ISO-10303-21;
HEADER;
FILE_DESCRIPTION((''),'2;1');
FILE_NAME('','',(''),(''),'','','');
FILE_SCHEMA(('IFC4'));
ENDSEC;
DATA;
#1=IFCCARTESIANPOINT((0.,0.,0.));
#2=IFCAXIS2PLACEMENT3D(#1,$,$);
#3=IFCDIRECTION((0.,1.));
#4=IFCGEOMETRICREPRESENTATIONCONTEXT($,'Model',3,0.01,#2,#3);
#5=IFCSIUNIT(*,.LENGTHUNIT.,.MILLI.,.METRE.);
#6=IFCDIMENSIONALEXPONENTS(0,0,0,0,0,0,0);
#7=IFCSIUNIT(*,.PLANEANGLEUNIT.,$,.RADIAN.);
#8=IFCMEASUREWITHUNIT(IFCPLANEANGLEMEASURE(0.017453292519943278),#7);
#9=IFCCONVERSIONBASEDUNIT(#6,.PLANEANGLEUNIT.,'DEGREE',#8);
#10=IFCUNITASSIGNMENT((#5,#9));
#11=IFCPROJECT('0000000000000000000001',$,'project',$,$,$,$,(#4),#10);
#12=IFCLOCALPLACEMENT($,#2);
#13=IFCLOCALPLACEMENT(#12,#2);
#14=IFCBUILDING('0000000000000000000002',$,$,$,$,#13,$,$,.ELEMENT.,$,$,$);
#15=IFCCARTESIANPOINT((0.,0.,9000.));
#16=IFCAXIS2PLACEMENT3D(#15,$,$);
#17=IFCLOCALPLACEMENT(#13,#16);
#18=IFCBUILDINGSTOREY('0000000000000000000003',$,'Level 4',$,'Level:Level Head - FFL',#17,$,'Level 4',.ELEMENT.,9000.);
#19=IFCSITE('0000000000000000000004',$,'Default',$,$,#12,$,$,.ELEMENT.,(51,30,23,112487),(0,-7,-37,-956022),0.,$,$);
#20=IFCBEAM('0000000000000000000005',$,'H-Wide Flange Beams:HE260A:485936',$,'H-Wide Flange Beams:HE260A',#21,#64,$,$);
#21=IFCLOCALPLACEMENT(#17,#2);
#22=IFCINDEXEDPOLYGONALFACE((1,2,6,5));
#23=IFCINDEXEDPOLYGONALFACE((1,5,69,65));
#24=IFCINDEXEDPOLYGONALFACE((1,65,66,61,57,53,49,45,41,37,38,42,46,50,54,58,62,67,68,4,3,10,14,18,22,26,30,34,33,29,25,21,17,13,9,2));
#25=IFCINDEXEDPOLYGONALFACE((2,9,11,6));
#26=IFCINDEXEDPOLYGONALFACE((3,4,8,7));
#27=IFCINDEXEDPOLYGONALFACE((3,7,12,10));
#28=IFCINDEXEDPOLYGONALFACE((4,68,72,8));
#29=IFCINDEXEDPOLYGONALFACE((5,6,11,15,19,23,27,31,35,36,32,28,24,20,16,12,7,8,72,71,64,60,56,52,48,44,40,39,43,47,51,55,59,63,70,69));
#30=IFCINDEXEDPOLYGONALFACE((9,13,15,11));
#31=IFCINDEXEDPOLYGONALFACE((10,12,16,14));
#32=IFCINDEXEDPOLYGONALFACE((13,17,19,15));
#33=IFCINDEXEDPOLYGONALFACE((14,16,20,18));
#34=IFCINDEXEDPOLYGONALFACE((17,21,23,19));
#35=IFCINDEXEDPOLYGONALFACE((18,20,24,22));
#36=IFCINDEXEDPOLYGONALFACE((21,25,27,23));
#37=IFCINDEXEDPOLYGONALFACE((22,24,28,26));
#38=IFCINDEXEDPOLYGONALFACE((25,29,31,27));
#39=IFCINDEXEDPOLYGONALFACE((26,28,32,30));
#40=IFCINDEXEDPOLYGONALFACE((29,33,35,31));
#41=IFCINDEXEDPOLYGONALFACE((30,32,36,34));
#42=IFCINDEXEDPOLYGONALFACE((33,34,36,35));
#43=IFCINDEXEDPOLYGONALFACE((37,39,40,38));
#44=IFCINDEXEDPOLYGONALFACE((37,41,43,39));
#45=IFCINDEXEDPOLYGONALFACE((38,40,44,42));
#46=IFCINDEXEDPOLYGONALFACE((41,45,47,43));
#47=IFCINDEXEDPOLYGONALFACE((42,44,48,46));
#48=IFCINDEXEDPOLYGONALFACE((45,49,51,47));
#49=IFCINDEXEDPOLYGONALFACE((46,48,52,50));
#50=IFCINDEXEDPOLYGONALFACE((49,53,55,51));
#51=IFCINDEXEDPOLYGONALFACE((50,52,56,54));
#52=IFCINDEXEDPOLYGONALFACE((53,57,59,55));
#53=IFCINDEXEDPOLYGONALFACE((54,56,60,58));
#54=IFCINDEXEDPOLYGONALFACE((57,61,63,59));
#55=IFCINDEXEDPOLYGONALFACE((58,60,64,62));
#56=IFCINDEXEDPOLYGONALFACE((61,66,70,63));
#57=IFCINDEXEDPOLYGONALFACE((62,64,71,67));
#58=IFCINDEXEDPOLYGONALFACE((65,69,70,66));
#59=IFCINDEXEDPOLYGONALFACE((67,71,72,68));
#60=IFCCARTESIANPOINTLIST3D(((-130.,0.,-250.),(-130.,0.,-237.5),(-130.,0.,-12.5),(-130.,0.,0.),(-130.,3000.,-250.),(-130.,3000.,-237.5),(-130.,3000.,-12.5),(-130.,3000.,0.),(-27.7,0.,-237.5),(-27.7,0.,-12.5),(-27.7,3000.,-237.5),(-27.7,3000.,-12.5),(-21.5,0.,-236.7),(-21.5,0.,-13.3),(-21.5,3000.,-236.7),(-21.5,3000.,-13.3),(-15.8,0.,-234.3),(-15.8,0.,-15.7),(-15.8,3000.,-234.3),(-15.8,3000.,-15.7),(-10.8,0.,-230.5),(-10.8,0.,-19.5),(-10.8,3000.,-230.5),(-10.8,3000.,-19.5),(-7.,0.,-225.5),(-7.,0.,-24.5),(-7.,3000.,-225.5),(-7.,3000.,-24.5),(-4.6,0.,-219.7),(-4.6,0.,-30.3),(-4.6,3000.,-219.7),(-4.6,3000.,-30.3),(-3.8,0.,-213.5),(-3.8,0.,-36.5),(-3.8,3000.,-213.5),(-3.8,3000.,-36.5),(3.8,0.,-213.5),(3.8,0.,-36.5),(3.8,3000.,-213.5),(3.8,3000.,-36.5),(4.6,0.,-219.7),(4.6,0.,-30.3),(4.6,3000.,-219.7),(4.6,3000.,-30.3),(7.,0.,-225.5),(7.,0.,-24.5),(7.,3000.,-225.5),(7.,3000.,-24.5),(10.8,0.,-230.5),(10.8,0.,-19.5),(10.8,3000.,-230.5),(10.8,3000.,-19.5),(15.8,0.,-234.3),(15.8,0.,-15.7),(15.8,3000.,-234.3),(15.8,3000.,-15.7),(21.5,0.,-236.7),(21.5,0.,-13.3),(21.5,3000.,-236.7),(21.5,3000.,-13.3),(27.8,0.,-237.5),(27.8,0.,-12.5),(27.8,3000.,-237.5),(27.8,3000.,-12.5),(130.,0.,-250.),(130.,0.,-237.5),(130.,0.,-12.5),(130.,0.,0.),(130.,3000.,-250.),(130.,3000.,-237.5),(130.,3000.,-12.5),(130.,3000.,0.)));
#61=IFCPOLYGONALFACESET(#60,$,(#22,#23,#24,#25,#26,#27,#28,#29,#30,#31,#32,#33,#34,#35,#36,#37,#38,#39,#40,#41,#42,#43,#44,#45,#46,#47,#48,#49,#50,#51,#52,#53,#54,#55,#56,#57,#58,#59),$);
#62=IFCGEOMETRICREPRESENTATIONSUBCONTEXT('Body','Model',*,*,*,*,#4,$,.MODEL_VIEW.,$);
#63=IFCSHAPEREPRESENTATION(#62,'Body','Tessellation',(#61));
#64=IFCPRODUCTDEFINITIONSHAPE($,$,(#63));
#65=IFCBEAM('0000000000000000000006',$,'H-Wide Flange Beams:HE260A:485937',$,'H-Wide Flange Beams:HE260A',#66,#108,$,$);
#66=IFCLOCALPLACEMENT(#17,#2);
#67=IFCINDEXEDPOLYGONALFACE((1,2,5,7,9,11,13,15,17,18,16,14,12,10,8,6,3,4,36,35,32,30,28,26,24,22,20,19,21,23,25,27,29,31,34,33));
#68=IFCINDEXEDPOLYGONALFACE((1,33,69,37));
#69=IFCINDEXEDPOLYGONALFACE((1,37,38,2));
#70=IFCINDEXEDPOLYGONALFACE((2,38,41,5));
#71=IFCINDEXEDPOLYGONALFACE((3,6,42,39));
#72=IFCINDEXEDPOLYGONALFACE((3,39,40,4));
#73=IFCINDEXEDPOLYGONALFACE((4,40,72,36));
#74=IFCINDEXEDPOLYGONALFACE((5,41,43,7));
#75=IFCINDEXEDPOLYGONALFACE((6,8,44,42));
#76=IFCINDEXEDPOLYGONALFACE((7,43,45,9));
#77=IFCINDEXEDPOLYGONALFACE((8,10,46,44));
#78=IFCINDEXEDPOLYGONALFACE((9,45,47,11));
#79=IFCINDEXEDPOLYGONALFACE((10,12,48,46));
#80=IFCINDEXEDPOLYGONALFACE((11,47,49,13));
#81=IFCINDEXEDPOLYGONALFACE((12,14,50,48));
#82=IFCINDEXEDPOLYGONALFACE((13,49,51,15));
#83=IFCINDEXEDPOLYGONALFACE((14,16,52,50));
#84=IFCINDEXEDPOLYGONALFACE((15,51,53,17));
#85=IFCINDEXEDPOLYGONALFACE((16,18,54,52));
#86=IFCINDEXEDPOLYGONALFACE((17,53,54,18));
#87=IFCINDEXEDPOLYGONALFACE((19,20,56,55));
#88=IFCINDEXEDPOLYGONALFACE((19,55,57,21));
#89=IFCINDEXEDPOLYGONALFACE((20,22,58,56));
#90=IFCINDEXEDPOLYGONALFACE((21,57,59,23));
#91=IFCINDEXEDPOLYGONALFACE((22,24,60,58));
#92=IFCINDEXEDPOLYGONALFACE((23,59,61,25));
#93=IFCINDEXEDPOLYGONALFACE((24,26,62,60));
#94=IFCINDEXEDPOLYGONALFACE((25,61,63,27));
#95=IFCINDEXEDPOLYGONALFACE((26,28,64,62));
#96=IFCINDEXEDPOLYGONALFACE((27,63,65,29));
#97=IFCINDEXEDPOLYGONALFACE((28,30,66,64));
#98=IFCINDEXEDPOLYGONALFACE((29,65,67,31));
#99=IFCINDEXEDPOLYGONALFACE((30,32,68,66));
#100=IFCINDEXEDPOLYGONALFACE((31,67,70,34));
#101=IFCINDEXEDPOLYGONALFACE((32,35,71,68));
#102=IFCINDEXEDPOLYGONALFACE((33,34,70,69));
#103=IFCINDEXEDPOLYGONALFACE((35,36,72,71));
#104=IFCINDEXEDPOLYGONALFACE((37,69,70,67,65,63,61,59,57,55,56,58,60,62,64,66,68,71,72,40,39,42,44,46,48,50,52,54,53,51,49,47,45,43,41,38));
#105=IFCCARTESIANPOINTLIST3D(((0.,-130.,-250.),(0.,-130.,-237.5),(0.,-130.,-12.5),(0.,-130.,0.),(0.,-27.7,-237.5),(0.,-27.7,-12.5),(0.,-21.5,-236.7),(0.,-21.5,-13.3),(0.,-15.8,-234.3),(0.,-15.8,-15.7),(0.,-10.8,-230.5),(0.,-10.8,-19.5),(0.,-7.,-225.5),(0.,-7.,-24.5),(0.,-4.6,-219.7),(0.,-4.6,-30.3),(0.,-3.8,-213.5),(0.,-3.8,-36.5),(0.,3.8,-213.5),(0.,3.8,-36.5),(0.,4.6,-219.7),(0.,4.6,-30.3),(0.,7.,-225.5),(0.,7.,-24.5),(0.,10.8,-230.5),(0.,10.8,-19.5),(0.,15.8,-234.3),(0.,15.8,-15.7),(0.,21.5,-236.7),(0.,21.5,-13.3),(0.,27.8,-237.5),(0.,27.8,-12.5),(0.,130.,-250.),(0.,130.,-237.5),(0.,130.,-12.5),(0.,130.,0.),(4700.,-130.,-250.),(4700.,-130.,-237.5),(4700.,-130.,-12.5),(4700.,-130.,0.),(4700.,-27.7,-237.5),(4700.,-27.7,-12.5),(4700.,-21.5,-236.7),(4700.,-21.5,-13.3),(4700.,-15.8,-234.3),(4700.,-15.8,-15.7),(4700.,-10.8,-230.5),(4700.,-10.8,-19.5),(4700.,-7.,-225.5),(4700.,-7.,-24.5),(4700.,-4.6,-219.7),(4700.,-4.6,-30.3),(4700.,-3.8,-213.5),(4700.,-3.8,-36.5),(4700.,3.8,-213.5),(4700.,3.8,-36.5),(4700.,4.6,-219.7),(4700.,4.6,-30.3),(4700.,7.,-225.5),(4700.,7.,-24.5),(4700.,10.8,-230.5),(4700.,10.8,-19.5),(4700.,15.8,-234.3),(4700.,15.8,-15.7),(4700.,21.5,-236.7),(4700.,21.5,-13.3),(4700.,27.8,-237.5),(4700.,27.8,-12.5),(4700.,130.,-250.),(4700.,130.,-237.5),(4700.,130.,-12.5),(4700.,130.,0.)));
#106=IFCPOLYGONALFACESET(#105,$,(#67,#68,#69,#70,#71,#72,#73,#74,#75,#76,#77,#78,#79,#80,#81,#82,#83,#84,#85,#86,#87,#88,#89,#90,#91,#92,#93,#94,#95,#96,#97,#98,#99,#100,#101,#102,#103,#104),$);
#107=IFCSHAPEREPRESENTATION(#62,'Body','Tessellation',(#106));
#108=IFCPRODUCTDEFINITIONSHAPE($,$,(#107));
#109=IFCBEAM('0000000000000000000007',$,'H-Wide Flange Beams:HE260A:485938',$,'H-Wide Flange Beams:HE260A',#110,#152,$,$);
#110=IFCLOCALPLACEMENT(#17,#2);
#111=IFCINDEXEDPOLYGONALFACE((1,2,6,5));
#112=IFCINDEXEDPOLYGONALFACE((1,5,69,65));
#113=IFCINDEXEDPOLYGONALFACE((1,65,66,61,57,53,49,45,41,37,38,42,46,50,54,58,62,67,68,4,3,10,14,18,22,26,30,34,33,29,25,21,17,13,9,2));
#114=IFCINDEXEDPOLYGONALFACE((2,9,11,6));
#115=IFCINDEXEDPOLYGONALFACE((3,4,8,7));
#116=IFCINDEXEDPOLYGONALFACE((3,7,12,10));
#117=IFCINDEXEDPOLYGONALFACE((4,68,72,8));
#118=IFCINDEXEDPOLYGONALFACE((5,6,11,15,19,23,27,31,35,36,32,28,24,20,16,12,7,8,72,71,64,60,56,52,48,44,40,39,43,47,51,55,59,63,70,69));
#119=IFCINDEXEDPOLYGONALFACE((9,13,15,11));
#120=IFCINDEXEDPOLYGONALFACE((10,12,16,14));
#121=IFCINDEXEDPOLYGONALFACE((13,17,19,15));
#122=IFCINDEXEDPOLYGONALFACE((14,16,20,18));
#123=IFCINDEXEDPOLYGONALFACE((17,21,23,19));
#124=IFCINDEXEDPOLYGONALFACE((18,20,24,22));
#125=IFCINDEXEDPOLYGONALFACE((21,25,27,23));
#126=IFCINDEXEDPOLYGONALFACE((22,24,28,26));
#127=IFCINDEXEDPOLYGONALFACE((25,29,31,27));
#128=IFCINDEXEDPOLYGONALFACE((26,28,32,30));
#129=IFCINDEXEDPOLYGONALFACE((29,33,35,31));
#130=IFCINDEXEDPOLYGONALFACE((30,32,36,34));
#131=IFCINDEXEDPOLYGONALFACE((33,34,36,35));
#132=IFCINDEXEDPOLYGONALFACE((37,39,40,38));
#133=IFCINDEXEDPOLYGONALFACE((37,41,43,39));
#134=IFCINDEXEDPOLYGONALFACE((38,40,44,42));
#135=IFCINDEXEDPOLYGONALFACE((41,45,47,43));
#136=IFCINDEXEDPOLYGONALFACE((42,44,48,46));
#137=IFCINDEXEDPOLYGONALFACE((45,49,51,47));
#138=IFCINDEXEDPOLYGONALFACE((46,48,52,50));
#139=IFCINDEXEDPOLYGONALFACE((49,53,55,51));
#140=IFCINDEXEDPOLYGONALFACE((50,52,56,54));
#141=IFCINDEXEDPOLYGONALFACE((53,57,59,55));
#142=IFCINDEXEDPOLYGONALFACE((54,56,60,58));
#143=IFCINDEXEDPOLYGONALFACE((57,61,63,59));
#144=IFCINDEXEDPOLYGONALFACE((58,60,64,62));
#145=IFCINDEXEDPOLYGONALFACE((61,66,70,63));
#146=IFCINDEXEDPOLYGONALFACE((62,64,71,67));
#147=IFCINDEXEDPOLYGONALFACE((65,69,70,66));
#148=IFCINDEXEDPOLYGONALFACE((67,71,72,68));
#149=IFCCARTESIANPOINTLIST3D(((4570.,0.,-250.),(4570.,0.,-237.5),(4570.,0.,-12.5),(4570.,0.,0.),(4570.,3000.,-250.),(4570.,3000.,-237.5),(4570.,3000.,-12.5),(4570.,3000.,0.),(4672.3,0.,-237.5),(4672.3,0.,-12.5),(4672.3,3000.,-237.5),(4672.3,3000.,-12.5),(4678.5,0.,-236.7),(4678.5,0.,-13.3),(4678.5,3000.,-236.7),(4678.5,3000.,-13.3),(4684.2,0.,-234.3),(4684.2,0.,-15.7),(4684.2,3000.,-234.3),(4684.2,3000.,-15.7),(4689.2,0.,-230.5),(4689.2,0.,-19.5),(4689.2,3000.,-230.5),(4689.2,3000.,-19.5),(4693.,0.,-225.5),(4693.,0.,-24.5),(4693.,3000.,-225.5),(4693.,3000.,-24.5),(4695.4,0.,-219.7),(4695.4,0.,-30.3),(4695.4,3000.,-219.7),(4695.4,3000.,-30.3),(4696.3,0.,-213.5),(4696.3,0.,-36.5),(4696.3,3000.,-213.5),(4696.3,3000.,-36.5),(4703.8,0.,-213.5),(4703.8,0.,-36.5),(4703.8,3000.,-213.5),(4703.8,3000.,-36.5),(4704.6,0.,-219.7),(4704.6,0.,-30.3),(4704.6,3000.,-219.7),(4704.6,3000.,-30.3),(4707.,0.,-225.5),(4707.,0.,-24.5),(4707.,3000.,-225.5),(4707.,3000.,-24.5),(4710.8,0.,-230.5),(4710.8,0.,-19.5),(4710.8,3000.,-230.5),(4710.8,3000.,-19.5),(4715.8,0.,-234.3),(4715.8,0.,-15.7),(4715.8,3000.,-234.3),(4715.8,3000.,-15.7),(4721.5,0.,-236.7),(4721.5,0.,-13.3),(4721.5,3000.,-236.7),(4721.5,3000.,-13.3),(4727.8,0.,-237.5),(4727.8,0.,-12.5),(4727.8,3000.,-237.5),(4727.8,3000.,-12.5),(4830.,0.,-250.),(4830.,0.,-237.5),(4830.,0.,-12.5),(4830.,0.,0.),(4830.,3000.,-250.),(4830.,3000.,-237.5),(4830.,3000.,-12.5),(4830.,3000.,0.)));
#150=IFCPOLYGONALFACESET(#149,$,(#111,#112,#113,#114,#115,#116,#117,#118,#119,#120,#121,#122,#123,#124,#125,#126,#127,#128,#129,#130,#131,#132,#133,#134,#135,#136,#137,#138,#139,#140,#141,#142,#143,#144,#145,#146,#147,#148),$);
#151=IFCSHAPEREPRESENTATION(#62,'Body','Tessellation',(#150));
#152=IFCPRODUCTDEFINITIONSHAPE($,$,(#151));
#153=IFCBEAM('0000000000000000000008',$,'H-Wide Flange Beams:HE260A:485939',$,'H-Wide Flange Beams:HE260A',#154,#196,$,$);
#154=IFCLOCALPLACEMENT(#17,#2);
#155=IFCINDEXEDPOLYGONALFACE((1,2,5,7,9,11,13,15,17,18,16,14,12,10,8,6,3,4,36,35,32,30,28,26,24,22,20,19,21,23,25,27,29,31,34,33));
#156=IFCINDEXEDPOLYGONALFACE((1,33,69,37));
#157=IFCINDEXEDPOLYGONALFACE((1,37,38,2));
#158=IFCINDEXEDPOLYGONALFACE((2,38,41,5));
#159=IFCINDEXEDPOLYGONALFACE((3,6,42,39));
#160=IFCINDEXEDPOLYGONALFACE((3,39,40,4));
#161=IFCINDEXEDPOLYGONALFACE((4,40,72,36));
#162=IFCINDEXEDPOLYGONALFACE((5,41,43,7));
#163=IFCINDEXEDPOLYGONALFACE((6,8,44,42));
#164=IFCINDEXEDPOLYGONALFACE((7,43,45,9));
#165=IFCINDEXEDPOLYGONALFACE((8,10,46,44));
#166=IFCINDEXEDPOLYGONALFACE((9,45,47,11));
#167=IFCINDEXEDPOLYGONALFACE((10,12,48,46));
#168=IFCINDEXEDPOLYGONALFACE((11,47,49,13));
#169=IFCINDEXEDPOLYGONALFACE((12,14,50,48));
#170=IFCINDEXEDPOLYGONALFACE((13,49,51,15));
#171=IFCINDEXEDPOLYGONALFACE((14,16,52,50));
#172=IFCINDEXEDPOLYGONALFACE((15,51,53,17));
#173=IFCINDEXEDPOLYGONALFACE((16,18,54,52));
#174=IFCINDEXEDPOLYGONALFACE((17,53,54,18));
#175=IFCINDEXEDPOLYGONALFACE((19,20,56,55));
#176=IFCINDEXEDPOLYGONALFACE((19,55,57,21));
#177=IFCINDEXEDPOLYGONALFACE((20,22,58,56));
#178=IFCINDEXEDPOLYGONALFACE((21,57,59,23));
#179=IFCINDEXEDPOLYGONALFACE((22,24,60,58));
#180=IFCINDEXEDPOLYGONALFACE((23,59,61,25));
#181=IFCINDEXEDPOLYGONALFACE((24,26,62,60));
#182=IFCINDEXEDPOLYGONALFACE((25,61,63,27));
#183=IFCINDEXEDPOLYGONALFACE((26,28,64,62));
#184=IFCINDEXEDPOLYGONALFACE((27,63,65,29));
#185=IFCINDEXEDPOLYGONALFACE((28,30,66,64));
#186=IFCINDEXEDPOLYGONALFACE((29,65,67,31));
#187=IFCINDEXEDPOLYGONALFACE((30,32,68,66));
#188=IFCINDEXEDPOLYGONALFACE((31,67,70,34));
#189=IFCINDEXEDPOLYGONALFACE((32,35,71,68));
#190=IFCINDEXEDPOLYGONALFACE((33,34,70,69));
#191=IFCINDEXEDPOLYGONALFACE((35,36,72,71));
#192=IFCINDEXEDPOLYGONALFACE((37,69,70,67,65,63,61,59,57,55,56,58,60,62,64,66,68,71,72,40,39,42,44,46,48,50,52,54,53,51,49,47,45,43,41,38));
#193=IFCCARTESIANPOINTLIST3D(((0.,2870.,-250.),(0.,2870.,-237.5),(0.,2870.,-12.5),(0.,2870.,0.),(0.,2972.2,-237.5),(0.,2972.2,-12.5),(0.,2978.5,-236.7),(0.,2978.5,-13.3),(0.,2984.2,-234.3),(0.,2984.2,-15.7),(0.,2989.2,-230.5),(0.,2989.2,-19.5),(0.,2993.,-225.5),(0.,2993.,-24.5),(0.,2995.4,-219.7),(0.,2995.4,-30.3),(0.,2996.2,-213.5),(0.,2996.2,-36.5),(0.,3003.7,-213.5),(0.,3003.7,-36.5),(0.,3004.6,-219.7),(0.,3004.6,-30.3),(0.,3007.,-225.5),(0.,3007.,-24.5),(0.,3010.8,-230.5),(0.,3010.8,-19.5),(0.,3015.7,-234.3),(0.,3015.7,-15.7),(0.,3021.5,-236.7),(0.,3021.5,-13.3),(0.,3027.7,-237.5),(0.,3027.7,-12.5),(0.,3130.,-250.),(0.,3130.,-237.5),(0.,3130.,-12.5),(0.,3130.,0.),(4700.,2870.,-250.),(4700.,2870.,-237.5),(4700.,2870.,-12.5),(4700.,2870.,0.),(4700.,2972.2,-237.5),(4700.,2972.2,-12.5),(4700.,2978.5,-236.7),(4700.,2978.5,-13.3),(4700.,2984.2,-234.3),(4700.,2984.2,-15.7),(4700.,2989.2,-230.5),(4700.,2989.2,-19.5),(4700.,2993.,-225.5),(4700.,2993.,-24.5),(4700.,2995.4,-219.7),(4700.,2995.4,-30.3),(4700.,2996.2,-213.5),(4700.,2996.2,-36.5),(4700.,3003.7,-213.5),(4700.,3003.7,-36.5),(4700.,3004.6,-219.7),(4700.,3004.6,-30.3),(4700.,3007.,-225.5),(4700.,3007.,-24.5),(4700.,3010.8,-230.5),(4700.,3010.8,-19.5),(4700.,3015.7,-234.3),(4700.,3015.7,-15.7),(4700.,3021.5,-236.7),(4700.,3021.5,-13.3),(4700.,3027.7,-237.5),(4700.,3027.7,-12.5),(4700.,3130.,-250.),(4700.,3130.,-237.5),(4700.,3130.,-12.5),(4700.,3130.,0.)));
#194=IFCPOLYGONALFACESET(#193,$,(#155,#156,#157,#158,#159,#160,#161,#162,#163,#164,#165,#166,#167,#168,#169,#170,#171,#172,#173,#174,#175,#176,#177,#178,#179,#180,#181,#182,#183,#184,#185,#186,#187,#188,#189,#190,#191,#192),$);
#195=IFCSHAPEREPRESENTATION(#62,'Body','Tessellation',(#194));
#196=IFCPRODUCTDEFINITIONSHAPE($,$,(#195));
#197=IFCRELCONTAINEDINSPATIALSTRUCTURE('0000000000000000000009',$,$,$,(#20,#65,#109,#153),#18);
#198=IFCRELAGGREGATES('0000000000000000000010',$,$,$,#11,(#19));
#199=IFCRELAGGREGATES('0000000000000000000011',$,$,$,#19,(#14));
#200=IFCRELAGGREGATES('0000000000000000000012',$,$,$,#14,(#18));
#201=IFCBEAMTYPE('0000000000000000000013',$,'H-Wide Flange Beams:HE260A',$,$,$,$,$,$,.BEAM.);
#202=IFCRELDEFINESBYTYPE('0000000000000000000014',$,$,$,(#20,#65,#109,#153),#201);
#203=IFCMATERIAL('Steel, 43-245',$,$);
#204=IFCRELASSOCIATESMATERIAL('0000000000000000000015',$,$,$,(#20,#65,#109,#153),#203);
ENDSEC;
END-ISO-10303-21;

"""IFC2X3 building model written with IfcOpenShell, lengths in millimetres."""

from ifc_helpers import new_model, entity, si_unit, converted_unit, direction, frame, frame_2d, origin, place, context, subcontext, project, spatial, i_section, extrude, material, type_object, element, save


model = new_model("IFC2X3")

# Units and contexts
model_context = context("Model", 3, precision=0.01, world=origin(), true_north=direction((0.0, 1.0)))
body_context = subcontext(model_context, "Body", "Model", "MODEL_VIEW")
ifc_project = project(units=[si_unit("LENGTHUNIT", "METRE", prefix="MILLI"), converted_unit("PLANEANGLEUNIT", "DEGREE", entity("IfcPlaneAngleMeasure", 0.017453292519943278), si_unit("PLANEANGLEUNIT", "RADIAN"), dimensions=[0, 0, 0, 0, 0, 0, 0])], contexts=[model_context])

# Site, building, storey
site_placement = place(None, origin())
site = spatial("IfcSite", under=ifc_project, at=site_placement, Name="Default", CompositionType="ELEMENT", RefLatitude=(51, 30, 23, 112487), RefLongitude=(0, -7, -37, -956022), RefElevation=0.0)
building_placement = place(site_placement, origin())
building = spatial("IfcBuilding", under=site, at=building_placement, CompositionType="ELEMENT")
storey_placement = place(building_placement, frame((0.0, 0.0, 9000.0)))
storey = spatial("IfcBuildingStorey", under=building, at=storey_placement, Name="Level 4", ObjectType="Level:Level Head - FFL", LongName="Level 4", CompositionType="ELEMENT", Elevation=9000.0)

# Beams
ifc_material = material(Name="Steel, 43-245")
beam_type_1 = type_object("IfcBeamType", Name="H-Wide Flange Beams:HE260A", PredefinedType="BEAM")
beam_1_placement = place(storey_placement, frame((0.0, 3000.0, 0.0), z_axis=(0.0, 0.0, 1.0), x_axis=(0.0, -1.0, 0.0)))
element("IfcBeam", 1, at=beam_1_placement, inside=storey, type_object=beam_type_1, material=ifc_material, Name="H-Wide Flange Beams:HE260A:485936", ObjectType="H-Wide Flange Beams:HE260A", context=body_context, shape_type="SweptSolid", body=[
    extrude(i_section(OverallWidth=260.0, OverallDepth=250.0, WebThickness=7.5, FlangeThickness=12.5, FilletRadius=24.0, at=frame_2d((0.0, 0.0), x_axis=(0.0, 1.0))), frame((0.0, 0.0, -125.0), z_axis=(1.0, 0.0, 0.0), x_axis=(0.0, 0.0, -1.0)), (0.0, 0.0, 1.0), 3000.0),
])
beam_2_placement = place(storey_placement, origin())
element("IfcBeam", 2, at=beam_2_placement, inside=storey, type_object=beam_type_1, material=ifc_material, Name="H-Wide Flange Beams:HE260A:485937", ObjectType="H-Wide Flange Beams:HE260A", context=body_context, shape_type="SweptSolid", body=[
    extrude(i_section(OverallWidth=260.0, OverallDepth=250.0, WebThickness=7.5, FlangeThickness=12.5, FilletRadius=24.0, at=frame_2d((0.0, 0.0), x_axis=(0.0, 1.0))), frame((0.0, 0.0, -125.0), z_axis=(1.0, 0.0, 0.0), x_axis=(0.0, 0.0, -1.0)), (0.0, 0.0, 1.0), 4700.0),
])
beam_3_placement = place(storey_placement, frame((4700.0, 0.0, 0.0), z_axis=(0.0, 0.0, 1.0), x_axis=(0.0, 1.0, 0.0)))
element("IfcBeam", 3, at=beam_3_placement, inside=storey, type_object=beam_type_1, material=ifc_material, Name="H-Wide Flange Beams:HE260A:485938", ObjectType="H-Wide Flange Beams:HE260A", context=body_context, shape_type="SweptSolid", body=[
    extrude(i_section(OverallWidth=260.0, OverallDepth=250.0, WebThickness=7.5, FlangeThickness=12.5, FilletRadius=24.0, at=frame_2d((0.0, 0.0), x_axis=(0.0, 1.0))), frame((0.0, 0.0, -125.0), z_axis=(1.0, 0.0, 0.0), x_axis=(0.0, 0.0, -1.0)), (0.0, 0.0, 1.0), 3000.0),
])
beam_4_placement = place(storey_placement, frame((4700.0, 3000.0, 0.0), z_axis=(0.0, 0.0, 1.0), x_axis=(-1.0, 0.0, 0.0)))
element("IfcBeam", 4, at=beam_4_placement, inside=storey, type_object=beam_type_1, material=ifc_material, Name="H-Wide Flange Beams:HE260A:485939", ObjectType="H-Wide Flange Beams:HE260A", context=body_context, shape_type="SweptSolid", body=[
    extrude(i_section(OverallWidth=260.0, OverallDepth=250.0, WebThickness=7.5, FlangeThickness=12.5, FilletRadius=24.0, at=frame_2d((0.0, 0.0), x_axis=(0.0, 1.0))), frame((0.0, 0.0, -125.0), z_axis=(1.0, 0.0, 0.0), x_axis=(0.0, 0.0, -1.0)), (0.0, 0.0, 1.0), 4700.0),
])

save(model, "model.ifc")
